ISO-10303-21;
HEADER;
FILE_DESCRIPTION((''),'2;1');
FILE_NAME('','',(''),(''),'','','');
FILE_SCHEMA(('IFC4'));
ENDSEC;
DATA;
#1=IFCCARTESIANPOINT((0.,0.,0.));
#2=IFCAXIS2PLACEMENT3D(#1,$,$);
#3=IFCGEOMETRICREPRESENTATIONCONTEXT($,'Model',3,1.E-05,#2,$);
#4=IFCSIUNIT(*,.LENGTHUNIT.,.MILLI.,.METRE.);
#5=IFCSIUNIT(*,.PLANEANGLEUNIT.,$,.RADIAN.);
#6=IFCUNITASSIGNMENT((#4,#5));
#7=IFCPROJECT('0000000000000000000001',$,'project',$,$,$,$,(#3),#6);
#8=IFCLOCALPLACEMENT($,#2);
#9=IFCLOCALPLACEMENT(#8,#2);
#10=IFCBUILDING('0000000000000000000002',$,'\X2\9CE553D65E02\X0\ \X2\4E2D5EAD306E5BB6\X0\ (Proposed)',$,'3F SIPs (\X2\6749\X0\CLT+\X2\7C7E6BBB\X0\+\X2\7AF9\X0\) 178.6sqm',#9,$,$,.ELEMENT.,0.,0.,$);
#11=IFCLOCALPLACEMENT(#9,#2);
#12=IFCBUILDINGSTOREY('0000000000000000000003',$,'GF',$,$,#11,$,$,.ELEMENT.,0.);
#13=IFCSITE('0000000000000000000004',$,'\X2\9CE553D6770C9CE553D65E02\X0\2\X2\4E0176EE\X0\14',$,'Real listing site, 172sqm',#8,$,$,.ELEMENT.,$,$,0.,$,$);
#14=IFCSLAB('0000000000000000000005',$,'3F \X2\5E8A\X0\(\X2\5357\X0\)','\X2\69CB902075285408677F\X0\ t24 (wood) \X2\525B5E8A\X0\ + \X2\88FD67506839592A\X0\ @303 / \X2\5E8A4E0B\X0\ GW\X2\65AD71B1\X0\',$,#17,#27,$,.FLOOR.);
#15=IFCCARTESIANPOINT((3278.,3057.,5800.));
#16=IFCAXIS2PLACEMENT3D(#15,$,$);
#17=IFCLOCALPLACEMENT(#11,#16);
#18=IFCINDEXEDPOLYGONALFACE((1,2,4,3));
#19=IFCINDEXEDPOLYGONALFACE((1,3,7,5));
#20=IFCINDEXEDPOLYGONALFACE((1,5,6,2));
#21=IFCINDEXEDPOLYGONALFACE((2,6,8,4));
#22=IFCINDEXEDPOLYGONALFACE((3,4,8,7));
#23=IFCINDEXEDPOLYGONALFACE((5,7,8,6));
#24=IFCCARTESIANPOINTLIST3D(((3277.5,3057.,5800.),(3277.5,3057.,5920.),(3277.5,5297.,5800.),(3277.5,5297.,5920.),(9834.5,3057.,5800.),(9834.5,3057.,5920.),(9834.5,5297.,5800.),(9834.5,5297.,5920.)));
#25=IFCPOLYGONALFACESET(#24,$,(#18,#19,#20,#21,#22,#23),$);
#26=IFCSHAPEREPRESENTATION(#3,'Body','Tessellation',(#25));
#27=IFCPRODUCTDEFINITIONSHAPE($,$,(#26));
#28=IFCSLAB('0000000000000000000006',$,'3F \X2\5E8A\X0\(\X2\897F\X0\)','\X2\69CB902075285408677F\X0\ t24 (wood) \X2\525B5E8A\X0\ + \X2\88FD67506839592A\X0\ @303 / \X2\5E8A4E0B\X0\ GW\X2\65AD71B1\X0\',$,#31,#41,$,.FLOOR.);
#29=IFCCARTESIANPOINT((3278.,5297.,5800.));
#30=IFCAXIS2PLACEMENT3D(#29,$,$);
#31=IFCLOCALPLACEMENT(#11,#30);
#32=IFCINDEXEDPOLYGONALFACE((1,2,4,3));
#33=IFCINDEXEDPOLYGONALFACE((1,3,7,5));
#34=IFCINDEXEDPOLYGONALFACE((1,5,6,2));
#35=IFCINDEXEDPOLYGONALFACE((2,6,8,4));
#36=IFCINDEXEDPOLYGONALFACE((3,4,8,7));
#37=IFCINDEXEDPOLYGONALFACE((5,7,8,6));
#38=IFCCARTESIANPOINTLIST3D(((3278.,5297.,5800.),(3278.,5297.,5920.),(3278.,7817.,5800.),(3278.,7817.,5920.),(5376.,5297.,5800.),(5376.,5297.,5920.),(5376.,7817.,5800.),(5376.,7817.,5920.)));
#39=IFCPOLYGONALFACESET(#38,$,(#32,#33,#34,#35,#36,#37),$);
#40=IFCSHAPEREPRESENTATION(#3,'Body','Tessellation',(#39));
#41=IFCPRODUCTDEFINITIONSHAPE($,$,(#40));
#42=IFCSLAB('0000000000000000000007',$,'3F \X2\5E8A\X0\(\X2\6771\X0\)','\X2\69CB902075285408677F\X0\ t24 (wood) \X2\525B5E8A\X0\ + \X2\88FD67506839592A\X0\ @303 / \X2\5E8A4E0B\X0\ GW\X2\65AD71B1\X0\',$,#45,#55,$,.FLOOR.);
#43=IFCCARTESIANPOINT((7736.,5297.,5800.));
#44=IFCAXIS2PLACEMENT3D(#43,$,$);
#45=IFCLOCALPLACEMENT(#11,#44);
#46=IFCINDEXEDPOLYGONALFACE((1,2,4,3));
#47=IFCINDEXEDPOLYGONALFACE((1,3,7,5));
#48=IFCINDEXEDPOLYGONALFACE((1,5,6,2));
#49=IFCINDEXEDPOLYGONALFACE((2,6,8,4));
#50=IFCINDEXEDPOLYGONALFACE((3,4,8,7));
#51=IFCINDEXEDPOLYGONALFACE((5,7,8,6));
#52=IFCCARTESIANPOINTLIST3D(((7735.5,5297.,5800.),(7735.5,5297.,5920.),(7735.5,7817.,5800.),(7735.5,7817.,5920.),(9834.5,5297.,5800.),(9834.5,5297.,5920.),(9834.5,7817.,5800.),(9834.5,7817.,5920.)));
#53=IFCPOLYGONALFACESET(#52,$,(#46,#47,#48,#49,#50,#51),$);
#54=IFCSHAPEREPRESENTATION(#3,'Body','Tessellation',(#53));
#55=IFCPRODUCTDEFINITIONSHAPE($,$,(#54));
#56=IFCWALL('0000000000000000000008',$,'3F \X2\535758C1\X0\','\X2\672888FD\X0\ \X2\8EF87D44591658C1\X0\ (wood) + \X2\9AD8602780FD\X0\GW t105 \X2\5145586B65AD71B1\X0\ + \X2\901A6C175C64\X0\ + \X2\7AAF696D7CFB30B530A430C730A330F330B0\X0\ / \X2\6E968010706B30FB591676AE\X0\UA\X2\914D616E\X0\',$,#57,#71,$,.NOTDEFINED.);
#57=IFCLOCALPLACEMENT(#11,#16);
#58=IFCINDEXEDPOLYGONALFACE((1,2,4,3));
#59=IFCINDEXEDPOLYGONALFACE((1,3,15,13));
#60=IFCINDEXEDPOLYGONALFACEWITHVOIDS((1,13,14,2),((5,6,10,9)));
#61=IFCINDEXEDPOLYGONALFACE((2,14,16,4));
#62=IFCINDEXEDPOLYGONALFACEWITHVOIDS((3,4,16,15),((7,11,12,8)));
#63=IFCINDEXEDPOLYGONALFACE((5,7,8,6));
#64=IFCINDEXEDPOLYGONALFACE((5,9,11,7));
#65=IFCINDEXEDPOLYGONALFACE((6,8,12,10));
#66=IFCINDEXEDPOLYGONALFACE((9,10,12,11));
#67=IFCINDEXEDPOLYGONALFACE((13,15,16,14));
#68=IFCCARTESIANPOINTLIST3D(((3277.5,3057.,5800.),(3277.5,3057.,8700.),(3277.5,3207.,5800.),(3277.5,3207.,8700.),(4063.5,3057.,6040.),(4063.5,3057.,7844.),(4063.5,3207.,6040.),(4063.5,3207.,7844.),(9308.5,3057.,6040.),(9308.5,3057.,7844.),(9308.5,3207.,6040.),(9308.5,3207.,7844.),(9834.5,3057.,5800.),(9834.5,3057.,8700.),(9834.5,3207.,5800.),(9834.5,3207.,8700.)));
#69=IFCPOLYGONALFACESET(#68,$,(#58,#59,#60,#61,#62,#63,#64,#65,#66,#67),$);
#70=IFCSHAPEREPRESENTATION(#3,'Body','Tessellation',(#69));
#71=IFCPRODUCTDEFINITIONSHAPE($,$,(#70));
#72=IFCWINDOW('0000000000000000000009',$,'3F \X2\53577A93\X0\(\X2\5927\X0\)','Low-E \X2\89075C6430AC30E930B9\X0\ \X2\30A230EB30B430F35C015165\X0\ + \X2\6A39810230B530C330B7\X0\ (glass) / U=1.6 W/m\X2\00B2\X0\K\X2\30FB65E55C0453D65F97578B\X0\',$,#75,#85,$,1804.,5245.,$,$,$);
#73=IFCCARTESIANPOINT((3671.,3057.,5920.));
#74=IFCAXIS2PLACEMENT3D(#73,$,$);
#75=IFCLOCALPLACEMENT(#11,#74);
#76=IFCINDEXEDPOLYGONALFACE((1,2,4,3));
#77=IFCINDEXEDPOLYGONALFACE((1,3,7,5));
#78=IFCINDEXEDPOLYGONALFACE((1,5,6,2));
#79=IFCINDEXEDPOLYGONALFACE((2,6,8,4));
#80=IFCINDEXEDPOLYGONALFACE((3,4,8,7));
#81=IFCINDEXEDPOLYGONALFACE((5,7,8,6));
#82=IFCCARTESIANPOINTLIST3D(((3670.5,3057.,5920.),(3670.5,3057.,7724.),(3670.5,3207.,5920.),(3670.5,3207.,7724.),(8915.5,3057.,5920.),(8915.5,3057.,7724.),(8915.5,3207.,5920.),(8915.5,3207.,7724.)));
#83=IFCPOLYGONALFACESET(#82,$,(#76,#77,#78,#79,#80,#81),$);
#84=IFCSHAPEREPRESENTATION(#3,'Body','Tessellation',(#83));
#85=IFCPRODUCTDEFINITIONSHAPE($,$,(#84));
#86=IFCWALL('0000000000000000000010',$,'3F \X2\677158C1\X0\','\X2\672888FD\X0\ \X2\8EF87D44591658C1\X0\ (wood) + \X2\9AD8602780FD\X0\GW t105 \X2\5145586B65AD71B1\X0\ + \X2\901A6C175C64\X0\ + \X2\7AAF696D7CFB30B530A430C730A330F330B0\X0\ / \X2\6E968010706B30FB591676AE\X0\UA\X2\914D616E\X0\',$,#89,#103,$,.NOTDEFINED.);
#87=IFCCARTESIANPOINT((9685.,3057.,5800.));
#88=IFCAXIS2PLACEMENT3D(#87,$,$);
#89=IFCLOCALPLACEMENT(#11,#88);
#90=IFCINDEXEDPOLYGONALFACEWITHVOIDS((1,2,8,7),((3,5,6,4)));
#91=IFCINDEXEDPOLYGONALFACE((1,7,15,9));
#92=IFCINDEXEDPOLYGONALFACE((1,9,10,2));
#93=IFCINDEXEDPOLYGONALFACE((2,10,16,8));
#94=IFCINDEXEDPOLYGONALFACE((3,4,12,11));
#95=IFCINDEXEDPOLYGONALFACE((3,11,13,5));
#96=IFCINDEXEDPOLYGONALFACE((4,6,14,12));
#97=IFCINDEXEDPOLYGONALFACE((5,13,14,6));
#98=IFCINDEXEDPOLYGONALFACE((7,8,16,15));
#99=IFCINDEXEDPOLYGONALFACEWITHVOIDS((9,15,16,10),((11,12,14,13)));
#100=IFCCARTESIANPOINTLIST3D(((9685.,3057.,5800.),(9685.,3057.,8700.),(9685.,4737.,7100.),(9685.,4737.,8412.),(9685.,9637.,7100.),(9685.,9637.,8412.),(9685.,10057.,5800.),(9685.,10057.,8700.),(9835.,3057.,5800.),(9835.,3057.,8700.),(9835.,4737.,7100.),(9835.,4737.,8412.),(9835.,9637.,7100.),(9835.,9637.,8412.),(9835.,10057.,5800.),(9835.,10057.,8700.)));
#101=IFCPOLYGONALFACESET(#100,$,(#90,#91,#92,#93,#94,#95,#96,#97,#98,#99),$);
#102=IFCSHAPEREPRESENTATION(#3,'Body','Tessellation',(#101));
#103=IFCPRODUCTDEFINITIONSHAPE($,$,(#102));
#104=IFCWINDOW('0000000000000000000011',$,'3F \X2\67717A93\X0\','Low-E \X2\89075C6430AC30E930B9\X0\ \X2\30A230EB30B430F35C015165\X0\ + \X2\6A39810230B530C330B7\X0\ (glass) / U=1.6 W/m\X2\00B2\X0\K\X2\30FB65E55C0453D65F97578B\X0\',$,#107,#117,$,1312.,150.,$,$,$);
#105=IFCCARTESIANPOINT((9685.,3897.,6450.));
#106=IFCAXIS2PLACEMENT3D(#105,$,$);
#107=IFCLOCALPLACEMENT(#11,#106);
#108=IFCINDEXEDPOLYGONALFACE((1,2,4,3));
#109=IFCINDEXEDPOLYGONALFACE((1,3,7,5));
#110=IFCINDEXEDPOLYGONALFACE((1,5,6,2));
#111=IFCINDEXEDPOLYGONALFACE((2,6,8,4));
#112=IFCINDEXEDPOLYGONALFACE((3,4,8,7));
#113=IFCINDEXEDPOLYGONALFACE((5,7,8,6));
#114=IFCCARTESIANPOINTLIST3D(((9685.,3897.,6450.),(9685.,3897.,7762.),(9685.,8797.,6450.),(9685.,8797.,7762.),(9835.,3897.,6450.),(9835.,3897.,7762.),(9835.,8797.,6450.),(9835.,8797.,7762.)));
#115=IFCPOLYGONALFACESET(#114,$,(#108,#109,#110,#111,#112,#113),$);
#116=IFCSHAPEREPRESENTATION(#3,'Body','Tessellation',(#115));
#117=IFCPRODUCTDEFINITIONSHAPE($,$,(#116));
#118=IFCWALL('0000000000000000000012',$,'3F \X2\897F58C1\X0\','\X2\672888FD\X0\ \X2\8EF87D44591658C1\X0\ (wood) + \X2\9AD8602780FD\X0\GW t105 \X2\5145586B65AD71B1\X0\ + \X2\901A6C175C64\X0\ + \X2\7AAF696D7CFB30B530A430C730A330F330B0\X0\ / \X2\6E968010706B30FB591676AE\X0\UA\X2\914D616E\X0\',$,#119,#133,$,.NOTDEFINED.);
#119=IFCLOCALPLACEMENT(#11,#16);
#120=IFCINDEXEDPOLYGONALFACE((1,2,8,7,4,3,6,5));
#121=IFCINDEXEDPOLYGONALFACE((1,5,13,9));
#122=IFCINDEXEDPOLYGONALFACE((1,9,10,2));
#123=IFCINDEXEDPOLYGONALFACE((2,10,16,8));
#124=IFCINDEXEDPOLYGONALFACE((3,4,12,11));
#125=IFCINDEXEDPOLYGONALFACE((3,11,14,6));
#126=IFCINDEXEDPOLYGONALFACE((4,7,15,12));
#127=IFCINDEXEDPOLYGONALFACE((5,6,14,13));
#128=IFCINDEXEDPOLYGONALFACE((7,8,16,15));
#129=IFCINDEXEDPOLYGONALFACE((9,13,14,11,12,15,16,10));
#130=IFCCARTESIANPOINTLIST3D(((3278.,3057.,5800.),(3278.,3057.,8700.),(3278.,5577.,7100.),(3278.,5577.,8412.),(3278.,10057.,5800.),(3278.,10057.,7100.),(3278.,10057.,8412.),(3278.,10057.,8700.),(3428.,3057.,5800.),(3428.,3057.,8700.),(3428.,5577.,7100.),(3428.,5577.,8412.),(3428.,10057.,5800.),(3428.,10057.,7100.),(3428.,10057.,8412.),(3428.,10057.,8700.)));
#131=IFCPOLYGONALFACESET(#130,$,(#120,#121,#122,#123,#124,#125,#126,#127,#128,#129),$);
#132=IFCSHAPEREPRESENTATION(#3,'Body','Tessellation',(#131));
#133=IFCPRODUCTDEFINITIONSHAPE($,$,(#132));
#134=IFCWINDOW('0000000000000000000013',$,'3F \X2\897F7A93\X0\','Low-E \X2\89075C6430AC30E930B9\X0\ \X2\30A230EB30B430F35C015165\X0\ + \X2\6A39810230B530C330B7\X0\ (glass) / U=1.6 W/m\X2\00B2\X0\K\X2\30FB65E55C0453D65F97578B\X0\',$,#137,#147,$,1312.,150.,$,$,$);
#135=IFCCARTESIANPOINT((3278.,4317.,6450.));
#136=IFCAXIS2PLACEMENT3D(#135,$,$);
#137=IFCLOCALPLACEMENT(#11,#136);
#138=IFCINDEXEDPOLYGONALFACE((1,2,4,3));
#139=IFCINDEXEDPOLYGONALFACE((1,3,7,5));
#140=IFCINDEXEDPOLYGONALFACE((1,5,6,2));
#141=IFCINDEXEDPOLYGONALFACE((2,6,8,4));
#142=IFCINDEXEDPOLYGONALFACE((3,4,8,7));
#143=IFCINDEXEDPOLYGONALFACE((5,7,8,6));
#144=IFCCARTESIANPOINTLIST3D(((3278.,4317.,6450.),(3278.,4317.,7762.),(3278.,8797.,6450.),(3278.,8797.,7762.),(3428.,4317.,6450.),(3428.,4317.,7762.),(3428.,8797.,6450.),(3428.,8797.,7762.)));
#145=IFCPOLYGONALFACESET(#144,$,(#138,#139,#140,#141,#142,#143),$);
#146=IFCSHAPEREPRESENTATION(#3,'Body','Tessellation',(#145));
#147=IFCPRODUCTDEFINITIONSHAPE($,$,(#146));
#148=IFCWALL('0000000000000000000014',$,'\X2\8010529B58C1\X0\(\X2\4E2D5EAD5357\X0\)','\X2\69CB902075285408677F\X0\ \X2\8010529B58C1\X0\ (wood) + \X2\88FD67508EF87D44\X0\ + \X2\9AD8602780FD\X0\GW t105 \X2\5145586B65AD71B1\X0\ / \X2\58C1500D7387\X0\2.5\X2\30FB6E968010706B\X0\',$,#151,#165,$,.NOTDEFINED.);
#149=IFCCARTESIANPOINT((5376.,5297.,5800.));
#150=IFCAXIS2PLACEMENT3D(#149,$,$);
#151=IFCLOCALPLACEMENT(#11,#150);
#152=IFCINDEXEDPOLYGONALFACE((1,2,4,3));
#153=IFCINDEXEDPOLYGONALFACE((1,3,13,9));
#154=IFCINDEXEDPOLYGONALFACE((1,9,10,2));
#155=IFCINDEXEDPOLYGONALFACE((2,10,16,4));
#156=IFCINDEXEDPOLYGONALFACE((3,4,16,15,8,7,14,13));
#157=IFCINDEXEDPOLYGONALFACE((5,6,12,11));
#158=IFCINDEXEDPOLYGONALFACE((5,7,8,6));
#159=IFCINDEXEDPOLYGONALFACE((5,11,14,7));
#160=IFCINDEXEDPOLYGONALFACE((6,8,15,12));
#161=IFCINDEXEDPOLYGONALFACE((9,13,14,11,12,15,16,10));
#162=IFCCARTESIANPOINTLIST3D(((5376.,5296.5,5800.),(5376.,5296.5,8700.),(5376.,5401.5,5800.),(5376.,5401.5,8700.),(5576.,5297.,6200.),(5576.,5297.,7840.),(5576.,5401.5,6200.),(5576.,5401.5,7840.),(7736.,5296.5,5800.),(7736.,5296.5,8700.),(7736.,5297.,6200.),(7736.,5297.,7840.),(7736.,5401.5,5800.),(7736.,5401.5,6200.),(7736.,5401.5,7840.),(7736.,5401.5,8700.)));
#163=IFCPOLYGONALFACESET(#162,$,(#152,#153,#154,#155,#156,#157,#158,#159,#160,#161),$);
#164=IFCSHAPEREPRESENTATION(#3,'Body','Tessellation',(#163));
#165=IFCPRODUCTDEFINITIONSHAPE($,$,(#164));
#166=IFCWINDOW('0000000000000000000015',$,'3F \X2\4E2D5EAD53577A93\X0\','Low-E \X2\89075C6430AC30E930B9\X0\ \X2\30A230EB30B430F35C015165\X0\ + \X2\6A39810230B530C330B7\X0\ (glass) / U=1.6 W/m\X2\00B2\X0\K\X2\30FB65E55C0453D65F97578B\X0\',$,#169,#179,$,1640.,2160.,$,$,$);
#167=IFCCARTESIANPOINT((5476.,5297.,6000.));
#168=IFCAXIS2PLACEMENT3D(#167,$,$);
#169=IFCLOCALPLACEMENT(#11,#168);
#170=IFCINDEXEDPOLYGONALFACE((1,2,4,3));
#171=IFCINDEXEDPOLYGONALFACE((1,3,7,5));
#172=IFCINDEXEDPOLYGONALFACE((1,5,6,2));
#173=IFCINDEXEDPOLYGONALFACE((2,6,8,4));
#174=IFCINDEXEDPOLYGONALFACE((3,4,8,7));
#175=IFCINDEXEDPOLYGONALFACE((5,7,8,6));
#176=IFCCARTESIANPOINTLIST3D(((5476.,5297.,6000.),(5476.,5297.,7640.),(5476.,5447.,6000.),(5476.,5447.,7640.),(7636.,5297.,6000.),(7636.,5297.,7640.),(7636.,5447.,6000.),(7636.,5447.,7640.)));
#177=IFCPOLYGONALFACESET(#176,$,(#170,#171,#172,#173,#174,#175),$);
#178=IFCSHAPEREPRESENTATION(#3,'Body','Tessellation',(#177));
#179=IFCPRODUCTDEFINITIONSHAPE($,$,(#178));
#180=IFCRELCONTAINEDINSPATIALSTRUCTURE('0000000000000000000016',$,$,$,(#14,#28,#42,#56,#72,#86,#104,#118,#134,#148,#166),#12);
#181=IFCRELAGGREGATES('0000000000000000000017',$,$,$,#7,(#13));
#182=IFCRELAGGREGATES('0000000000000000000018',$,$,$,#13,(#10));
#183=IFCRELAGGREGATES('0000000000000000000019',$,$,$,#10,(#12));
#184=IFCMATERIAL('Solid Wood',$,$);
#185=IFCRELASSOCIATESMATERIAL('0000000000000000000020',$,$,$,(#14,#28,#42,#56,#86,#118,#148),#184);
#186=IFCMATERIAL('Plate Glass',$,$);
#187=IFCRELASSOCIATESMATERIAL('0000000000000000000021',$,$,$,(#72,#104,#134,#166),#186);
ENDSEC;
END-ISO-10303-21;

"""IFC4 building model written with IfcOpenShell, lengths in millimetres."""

from ifc_helpers import new_model, si_unit, frame, frame_2d, origin, place, context, project, spatial, rectangle, extrude, material, element, fill, save


model = new_model("IFC4")

# Units and contexts
model_context = context("Model", 3, precision=1e-05, world=origin())
ifc_project = project(units=[si_unit("LENGTHUNIT", "METRE", prefix="MILLI"), si_unit("PLANEANGLEUNIT", "RADIAN")], contexts=[model_context])

# Site, building, storey
site_placement = place(None, origin())
site = spatial("IfcSite", under=ifc_project, at=site_placement, Name="鳥取県鳥取市2丁目14", ObjectType="Real listing site, 172sqm", CompositionType="ELEMENT", RefElevation=0.0)
building_placement = place(site_placement, origin())
building = spatial("IfcBuilding", under=site, at=building_placement, Name="鳥取市 中庭の家 (Proposed)", ObjectType="3F SIPs (杉CLT+籾殻+竹) 178.6sqm", CompositionType="ELEMENT", ElevationOfRefHeight=0.0, ElevationOfTerrain=0.0)
storey_placement = place(building_placement, origin())
storey = spatial("IfcBuildingStorey", under=building, at=storey_placement, Name="GF", CompositionType="ELEMENT", Elevation=0.0)

# Slabs
ifc_material_1 = material(Name="Solid Wood")
slab_1_placement = place(storey_placement, frame((3278.0, 3057.0, 5800.0)))
element("IfcSlab", 1, at=slab_1_placement, inside=storey, material=ifc_material_1, Name="3F 床(南)", Description="構造用合板 t24 (wood) 剛床 + 製材根太 @303 / 床下 GW断熱", PredefinedType="FLOOR", context=model_context, shape_type="SweptSolid", body=[
    extrude(rectangle(XDim=6557.0, YDim=2240.0, at=frame_2d((3278.0, 1120.0))), frame((3278.0, 3057.0, 5800.0)), (0.0, 0.0, 1.0), 120.0),
])
slab_2_placement = place(storey_placement, frame((3278.0, 5297.0, 5800.0)))
element("IfcSlab", 2, at=slab_2_placement, inside=storey, material=ifc_material_1, Name="3F 床(西)", Description="構造用合板 t24 (wood) 剛床 + 製材根太 @303 / 床下 GW断熱", PredefinedType="FLOOR", context=model_context, shape_type="SweptSolid", body=[
    extrude(rectangle(XDim=2098.0, YDim=2520.0, at=frame_2d((1049.0, 1260.0))), frame((3278.0, 5297.0, 5800.0)), (0.0, 0.0, 1.0), 120.0),
])
slab_3_placement = place(storey_placement, frame((7736.0, 5297.0, 5800.0)))
element("IfcSlab", 3, at=slab_3_placement, inside=storey, material=ifc_material_1, Name="3F 床(東)", Description="構造用合板 t24 (wood) 剛床 + 製材根太 @303 / 床下 GW断熱", PredefinedType="FLOOR", context=model_context, shape_type="SweptSolid", body=[
    extrude(rectangle(XDim=2099.0, YDim=2520.0, at=frame_2d((1049.0, 1260.0))), frame((7736.0, 5297.0, 5800.0)), (0.0, 0.0, 1.0), 120.0),
])

# Walls, openings, windows
wall_1_placement = place(storey_placement, frame((3278.0, 3057.0, 5800.0)))
wall_1 = element("IfcWall", 4, at=wall_1_placement, inside=storey, material=ifc_material_1, Name="3F 南壁", Description="木製 軸組外壁 (wood) + 高性能GW t105 充填断熱 + 通気層 + 窯業系サイディング / 準耐火・外皮UA配慮", PredefinedType="NOTDEFINED", context=model_context, shape_type="SweptSolid", body=[
    extrude(rectangle(XDim=6557.0, YDim=150.0, at=frame_2d((3278.0, 75.0))), frame((3278.0, 3057.0, 5800.0)), (0.0, 0.0, 1.0), 2900.0),
])
opening_1_placement = place(storey_placement, frame((3671.0, 3057.0, 5920.0)))
opening_1 = element("IfcOpeningElement", 5, at=opening_1_placement, cuts=wall_1, PredefinedType="NOTDEFINED", context=model_context, shape_type="SweptSolid", body=[
    extrude(rectangle(XDim=5245.0, YDim=150.0, at=frame_2d((2622.0, 75.0))), frame((3671.0, 3057.0, 5920.0)), (0.0, 0.0, 1.0), 1804.0),
])
ifc_material_2 = material(Name="Plate Glass")
window_1_placement = place(storey_placement, frame((3671.0, 3057.0, 5920.0)))
window_1 = element("IfcWindow", 6, at=window_1_placement, inside=storey, material=ifc_material_2, Name="3F 南窓(大)", Description="Low-E 複層ガラス アルゴン封入 + 樹脂サッシ (glass) / U=1.6 W/m²K・日射取得型", OverallHeight=1804.0, OverallWidth=5245.0, context=model_context, shape_type="SweptSolid", body=[
    extrude(rectangle(XDim=5245.0, YDim=150.0, at=frame_2d((2622.0, 75.0))), frame((3671.0, 3057.0, 5920.0)), (0.0, 0.0, 1.0), 1804.0),
])
fill(opening_1, window_1)
wall_2_placement = place(storey_placement, frame((9685.0, 3057.0, 5800.0)))
wall_2 = element("IfcWall", 7, at=wall_2_placement, inside=storey, material=ifc_material_1, Name="3F 東壁", Description="木製 軸組外壁 (wood) + 高性能GW t105 充填断熱 + 通気層 + 窯業系サイディング / 準耐火・外皮UA配慮", PredefinedType="NOTDEFINED", context=model_context, shape_type="SweptSolid", body=[
    extrude(rectangle(XDim=150.0, YDim=7000.0, at=frame_2d((75.0, 3500.0))), frame((9685.0, 3057.0, 5800.0)), (0.0, 0.0, 1.0), 2900.0),
])
opening_2_placement = place(storey_placement, frame((9685.0, 3897.0, 6450.0)))
opening_2 = element("IfcOpeningElement", 8, at=opening_2_placement, cuts=wall_2, PredefinedType="NOTDEFINED", context=model_context, shape_type="SweptSolid", body=[
    extrude(rectangle(XDim=150.0, YDim=4900.0, at=frame_2d((75.0, 2450.0))), frame((9685.0, 3897.0, 6450.0)), (0.0, 0.0, 1.0), 1312.0),
])
window_2_placement = place(storey_placement, frame((9685.0, 3897.0, 6450.0)))
window_2 = element("IfcWindow", 9, at=window_2_placement, inside=storey, material=ifc_material_2, Name="3F 東窓", Description="Low-E 複層ガラス アルゴン封入 + 樹脂サッシ (glass) / U=1.6 W/m²K・日射取得型", OverallHeight=1312.0, OverallWidth=150.0, context=model_context, shape_type="SweptSolid", body=[
    extrude(rectangle(XDim=150.0, YDim=4900.0, at=frame_2d((75.0, 2450.0))), frame((9685.0, 3897.0, 6450.0)), (0.0, 0.0, 1.0), 1312.0),
])
fill(opening_2, window_2)
wall_3_placement = place(storey_placement, frame((3278.0, 3057.0, 5800.0)))
wall_3 = element("IfcWall", 10, at=wall_3_placement, inside=storey, material=ifc_material_1, Name="3F 西壁", Description="木製 軸組外壁 (wood) + 高性能GW t105 充填断熱 + 通気層 + 窯業系サイディング / 準耐火・外皮UA配慮", PredefinedType="NOTDEFINED", context=model_context, shape_type="SweptSolid", body=[
    extrude(rectangle(XDim=150.0, YDim=7000.0, at=frame_2d((75.0, 3500.0))), frame((3278.0, 3057.0, 5800.0)), (0.0, 0.0, 1.0), 2900.0),
])
opening_3_placement = place(storey_placement, frame((3278.0, 4317.0, 6450.0)))
opening_3 = element("IfcOpeningElement", 11, at=opening_3_placement, cuts=wall_3, PredefinedType="NOTDEFINED", context=model_context, shape_type="SweptSolid", body=[
    extrude(rectangle(XDim=150.0, YDim=4480.0, at=frame_2d((75.0, 2240.0))), frame((3278.0, 4317.0, 6450.0)), (0.0, 0.0, 1.0), 1312.0),
])
window_3_placement = place(storey_placement, frame((3278.0, 4317.0, 6450.0)))
window_3 = element("IfcWindow", 12, at=window_3_placement, inside=storey, material=ifc_material_2, Name="3F 西窓", Description="Low-E 複層ガラス アルゴン封入 + 樹脂サッシ (glass) / U=1.6 W/m²K・日射取得型", OverallHeight=1312.0, OverallWidth=150.0, context=model_context, shape_type="SweptSolid", body=[
    extrude(rectangle(XDim=150.0, YDim=4480.0, at=frame_2d((75.0, 2240.0))), frame((3278.0, 4317.0, 6450.0)), (0.0, 0.0, 1.0), 1312.0),
])
fill(opening_3, window_3)
wall_4_placement = place(storey_placement, frame((5376.0, 5297.0, 5800.0)))
wall_4 = element("IfcWall", 13, at=wall_4_placement, inside=storey, material=ifc_material_1, Name="耐力壁(中庭南)", Description="構造用合板 耐力壁 (wood) + 製材軸組 + 高性能GW t105 充填断熱 / 壁倍率2.5・準耐火", PredefinedType="NOTDEFINED", context=model_context, shape_type="SweptSolid", body=[
    extrude(rectangle(XDim=2360.0, YDim=105.0, at=frame_2d((1180.0, 52.0))), frame((5376.0, 5297.0, 5800.0)), (0.0, 0.0, 1.0), 2900.0),
])
opening_4_placement = place(storey_placement, frame((5476.0, 5297.0, 6000.0)))
opening_4 = element("IfcOpeningElement", 14, at=opening_4_placement, cuts=wall_4, PredefinedType="NOTDEFINED", context=model_context, shape_type="SweptSolid", body=[
    extrude(rectangle(XDim=2160.0, YDim=150.0, at=frame_2d((1080.0, 75.0))), frame((5476.0, 5297.0, 6000.0)), (0.0, 0.0, 1.0), 1640.0),
])
window_4_placement = place(storey_placement, frame((5476.0, 5297.0, 6000.0)))
window_4 = element("IfcWindow", 15, at=window_4_placement, inside=storey, material=ifc_material_2, Name="3F 中庭南窓", Description="Low-E 複層ガラス アルゴン封入 + 樹脂サッシ (glass) / U=1.6 W/m²K・日射取得型", OverallHeight=1640.0, OverallWidth=2160.0, context=model_context, shape_type="SweptSolid", body=[
    extrude(rectangle(XDim=2160.0, YDim=150.0, at=frame_2d((1080.0, 75.0))), frame((5476.0, 5297.0, 6000.0)), (0.0, 0.0, 1.0), 1640.0),
])
fill(opening_4, window_4)

save(model, "model.ifc")
